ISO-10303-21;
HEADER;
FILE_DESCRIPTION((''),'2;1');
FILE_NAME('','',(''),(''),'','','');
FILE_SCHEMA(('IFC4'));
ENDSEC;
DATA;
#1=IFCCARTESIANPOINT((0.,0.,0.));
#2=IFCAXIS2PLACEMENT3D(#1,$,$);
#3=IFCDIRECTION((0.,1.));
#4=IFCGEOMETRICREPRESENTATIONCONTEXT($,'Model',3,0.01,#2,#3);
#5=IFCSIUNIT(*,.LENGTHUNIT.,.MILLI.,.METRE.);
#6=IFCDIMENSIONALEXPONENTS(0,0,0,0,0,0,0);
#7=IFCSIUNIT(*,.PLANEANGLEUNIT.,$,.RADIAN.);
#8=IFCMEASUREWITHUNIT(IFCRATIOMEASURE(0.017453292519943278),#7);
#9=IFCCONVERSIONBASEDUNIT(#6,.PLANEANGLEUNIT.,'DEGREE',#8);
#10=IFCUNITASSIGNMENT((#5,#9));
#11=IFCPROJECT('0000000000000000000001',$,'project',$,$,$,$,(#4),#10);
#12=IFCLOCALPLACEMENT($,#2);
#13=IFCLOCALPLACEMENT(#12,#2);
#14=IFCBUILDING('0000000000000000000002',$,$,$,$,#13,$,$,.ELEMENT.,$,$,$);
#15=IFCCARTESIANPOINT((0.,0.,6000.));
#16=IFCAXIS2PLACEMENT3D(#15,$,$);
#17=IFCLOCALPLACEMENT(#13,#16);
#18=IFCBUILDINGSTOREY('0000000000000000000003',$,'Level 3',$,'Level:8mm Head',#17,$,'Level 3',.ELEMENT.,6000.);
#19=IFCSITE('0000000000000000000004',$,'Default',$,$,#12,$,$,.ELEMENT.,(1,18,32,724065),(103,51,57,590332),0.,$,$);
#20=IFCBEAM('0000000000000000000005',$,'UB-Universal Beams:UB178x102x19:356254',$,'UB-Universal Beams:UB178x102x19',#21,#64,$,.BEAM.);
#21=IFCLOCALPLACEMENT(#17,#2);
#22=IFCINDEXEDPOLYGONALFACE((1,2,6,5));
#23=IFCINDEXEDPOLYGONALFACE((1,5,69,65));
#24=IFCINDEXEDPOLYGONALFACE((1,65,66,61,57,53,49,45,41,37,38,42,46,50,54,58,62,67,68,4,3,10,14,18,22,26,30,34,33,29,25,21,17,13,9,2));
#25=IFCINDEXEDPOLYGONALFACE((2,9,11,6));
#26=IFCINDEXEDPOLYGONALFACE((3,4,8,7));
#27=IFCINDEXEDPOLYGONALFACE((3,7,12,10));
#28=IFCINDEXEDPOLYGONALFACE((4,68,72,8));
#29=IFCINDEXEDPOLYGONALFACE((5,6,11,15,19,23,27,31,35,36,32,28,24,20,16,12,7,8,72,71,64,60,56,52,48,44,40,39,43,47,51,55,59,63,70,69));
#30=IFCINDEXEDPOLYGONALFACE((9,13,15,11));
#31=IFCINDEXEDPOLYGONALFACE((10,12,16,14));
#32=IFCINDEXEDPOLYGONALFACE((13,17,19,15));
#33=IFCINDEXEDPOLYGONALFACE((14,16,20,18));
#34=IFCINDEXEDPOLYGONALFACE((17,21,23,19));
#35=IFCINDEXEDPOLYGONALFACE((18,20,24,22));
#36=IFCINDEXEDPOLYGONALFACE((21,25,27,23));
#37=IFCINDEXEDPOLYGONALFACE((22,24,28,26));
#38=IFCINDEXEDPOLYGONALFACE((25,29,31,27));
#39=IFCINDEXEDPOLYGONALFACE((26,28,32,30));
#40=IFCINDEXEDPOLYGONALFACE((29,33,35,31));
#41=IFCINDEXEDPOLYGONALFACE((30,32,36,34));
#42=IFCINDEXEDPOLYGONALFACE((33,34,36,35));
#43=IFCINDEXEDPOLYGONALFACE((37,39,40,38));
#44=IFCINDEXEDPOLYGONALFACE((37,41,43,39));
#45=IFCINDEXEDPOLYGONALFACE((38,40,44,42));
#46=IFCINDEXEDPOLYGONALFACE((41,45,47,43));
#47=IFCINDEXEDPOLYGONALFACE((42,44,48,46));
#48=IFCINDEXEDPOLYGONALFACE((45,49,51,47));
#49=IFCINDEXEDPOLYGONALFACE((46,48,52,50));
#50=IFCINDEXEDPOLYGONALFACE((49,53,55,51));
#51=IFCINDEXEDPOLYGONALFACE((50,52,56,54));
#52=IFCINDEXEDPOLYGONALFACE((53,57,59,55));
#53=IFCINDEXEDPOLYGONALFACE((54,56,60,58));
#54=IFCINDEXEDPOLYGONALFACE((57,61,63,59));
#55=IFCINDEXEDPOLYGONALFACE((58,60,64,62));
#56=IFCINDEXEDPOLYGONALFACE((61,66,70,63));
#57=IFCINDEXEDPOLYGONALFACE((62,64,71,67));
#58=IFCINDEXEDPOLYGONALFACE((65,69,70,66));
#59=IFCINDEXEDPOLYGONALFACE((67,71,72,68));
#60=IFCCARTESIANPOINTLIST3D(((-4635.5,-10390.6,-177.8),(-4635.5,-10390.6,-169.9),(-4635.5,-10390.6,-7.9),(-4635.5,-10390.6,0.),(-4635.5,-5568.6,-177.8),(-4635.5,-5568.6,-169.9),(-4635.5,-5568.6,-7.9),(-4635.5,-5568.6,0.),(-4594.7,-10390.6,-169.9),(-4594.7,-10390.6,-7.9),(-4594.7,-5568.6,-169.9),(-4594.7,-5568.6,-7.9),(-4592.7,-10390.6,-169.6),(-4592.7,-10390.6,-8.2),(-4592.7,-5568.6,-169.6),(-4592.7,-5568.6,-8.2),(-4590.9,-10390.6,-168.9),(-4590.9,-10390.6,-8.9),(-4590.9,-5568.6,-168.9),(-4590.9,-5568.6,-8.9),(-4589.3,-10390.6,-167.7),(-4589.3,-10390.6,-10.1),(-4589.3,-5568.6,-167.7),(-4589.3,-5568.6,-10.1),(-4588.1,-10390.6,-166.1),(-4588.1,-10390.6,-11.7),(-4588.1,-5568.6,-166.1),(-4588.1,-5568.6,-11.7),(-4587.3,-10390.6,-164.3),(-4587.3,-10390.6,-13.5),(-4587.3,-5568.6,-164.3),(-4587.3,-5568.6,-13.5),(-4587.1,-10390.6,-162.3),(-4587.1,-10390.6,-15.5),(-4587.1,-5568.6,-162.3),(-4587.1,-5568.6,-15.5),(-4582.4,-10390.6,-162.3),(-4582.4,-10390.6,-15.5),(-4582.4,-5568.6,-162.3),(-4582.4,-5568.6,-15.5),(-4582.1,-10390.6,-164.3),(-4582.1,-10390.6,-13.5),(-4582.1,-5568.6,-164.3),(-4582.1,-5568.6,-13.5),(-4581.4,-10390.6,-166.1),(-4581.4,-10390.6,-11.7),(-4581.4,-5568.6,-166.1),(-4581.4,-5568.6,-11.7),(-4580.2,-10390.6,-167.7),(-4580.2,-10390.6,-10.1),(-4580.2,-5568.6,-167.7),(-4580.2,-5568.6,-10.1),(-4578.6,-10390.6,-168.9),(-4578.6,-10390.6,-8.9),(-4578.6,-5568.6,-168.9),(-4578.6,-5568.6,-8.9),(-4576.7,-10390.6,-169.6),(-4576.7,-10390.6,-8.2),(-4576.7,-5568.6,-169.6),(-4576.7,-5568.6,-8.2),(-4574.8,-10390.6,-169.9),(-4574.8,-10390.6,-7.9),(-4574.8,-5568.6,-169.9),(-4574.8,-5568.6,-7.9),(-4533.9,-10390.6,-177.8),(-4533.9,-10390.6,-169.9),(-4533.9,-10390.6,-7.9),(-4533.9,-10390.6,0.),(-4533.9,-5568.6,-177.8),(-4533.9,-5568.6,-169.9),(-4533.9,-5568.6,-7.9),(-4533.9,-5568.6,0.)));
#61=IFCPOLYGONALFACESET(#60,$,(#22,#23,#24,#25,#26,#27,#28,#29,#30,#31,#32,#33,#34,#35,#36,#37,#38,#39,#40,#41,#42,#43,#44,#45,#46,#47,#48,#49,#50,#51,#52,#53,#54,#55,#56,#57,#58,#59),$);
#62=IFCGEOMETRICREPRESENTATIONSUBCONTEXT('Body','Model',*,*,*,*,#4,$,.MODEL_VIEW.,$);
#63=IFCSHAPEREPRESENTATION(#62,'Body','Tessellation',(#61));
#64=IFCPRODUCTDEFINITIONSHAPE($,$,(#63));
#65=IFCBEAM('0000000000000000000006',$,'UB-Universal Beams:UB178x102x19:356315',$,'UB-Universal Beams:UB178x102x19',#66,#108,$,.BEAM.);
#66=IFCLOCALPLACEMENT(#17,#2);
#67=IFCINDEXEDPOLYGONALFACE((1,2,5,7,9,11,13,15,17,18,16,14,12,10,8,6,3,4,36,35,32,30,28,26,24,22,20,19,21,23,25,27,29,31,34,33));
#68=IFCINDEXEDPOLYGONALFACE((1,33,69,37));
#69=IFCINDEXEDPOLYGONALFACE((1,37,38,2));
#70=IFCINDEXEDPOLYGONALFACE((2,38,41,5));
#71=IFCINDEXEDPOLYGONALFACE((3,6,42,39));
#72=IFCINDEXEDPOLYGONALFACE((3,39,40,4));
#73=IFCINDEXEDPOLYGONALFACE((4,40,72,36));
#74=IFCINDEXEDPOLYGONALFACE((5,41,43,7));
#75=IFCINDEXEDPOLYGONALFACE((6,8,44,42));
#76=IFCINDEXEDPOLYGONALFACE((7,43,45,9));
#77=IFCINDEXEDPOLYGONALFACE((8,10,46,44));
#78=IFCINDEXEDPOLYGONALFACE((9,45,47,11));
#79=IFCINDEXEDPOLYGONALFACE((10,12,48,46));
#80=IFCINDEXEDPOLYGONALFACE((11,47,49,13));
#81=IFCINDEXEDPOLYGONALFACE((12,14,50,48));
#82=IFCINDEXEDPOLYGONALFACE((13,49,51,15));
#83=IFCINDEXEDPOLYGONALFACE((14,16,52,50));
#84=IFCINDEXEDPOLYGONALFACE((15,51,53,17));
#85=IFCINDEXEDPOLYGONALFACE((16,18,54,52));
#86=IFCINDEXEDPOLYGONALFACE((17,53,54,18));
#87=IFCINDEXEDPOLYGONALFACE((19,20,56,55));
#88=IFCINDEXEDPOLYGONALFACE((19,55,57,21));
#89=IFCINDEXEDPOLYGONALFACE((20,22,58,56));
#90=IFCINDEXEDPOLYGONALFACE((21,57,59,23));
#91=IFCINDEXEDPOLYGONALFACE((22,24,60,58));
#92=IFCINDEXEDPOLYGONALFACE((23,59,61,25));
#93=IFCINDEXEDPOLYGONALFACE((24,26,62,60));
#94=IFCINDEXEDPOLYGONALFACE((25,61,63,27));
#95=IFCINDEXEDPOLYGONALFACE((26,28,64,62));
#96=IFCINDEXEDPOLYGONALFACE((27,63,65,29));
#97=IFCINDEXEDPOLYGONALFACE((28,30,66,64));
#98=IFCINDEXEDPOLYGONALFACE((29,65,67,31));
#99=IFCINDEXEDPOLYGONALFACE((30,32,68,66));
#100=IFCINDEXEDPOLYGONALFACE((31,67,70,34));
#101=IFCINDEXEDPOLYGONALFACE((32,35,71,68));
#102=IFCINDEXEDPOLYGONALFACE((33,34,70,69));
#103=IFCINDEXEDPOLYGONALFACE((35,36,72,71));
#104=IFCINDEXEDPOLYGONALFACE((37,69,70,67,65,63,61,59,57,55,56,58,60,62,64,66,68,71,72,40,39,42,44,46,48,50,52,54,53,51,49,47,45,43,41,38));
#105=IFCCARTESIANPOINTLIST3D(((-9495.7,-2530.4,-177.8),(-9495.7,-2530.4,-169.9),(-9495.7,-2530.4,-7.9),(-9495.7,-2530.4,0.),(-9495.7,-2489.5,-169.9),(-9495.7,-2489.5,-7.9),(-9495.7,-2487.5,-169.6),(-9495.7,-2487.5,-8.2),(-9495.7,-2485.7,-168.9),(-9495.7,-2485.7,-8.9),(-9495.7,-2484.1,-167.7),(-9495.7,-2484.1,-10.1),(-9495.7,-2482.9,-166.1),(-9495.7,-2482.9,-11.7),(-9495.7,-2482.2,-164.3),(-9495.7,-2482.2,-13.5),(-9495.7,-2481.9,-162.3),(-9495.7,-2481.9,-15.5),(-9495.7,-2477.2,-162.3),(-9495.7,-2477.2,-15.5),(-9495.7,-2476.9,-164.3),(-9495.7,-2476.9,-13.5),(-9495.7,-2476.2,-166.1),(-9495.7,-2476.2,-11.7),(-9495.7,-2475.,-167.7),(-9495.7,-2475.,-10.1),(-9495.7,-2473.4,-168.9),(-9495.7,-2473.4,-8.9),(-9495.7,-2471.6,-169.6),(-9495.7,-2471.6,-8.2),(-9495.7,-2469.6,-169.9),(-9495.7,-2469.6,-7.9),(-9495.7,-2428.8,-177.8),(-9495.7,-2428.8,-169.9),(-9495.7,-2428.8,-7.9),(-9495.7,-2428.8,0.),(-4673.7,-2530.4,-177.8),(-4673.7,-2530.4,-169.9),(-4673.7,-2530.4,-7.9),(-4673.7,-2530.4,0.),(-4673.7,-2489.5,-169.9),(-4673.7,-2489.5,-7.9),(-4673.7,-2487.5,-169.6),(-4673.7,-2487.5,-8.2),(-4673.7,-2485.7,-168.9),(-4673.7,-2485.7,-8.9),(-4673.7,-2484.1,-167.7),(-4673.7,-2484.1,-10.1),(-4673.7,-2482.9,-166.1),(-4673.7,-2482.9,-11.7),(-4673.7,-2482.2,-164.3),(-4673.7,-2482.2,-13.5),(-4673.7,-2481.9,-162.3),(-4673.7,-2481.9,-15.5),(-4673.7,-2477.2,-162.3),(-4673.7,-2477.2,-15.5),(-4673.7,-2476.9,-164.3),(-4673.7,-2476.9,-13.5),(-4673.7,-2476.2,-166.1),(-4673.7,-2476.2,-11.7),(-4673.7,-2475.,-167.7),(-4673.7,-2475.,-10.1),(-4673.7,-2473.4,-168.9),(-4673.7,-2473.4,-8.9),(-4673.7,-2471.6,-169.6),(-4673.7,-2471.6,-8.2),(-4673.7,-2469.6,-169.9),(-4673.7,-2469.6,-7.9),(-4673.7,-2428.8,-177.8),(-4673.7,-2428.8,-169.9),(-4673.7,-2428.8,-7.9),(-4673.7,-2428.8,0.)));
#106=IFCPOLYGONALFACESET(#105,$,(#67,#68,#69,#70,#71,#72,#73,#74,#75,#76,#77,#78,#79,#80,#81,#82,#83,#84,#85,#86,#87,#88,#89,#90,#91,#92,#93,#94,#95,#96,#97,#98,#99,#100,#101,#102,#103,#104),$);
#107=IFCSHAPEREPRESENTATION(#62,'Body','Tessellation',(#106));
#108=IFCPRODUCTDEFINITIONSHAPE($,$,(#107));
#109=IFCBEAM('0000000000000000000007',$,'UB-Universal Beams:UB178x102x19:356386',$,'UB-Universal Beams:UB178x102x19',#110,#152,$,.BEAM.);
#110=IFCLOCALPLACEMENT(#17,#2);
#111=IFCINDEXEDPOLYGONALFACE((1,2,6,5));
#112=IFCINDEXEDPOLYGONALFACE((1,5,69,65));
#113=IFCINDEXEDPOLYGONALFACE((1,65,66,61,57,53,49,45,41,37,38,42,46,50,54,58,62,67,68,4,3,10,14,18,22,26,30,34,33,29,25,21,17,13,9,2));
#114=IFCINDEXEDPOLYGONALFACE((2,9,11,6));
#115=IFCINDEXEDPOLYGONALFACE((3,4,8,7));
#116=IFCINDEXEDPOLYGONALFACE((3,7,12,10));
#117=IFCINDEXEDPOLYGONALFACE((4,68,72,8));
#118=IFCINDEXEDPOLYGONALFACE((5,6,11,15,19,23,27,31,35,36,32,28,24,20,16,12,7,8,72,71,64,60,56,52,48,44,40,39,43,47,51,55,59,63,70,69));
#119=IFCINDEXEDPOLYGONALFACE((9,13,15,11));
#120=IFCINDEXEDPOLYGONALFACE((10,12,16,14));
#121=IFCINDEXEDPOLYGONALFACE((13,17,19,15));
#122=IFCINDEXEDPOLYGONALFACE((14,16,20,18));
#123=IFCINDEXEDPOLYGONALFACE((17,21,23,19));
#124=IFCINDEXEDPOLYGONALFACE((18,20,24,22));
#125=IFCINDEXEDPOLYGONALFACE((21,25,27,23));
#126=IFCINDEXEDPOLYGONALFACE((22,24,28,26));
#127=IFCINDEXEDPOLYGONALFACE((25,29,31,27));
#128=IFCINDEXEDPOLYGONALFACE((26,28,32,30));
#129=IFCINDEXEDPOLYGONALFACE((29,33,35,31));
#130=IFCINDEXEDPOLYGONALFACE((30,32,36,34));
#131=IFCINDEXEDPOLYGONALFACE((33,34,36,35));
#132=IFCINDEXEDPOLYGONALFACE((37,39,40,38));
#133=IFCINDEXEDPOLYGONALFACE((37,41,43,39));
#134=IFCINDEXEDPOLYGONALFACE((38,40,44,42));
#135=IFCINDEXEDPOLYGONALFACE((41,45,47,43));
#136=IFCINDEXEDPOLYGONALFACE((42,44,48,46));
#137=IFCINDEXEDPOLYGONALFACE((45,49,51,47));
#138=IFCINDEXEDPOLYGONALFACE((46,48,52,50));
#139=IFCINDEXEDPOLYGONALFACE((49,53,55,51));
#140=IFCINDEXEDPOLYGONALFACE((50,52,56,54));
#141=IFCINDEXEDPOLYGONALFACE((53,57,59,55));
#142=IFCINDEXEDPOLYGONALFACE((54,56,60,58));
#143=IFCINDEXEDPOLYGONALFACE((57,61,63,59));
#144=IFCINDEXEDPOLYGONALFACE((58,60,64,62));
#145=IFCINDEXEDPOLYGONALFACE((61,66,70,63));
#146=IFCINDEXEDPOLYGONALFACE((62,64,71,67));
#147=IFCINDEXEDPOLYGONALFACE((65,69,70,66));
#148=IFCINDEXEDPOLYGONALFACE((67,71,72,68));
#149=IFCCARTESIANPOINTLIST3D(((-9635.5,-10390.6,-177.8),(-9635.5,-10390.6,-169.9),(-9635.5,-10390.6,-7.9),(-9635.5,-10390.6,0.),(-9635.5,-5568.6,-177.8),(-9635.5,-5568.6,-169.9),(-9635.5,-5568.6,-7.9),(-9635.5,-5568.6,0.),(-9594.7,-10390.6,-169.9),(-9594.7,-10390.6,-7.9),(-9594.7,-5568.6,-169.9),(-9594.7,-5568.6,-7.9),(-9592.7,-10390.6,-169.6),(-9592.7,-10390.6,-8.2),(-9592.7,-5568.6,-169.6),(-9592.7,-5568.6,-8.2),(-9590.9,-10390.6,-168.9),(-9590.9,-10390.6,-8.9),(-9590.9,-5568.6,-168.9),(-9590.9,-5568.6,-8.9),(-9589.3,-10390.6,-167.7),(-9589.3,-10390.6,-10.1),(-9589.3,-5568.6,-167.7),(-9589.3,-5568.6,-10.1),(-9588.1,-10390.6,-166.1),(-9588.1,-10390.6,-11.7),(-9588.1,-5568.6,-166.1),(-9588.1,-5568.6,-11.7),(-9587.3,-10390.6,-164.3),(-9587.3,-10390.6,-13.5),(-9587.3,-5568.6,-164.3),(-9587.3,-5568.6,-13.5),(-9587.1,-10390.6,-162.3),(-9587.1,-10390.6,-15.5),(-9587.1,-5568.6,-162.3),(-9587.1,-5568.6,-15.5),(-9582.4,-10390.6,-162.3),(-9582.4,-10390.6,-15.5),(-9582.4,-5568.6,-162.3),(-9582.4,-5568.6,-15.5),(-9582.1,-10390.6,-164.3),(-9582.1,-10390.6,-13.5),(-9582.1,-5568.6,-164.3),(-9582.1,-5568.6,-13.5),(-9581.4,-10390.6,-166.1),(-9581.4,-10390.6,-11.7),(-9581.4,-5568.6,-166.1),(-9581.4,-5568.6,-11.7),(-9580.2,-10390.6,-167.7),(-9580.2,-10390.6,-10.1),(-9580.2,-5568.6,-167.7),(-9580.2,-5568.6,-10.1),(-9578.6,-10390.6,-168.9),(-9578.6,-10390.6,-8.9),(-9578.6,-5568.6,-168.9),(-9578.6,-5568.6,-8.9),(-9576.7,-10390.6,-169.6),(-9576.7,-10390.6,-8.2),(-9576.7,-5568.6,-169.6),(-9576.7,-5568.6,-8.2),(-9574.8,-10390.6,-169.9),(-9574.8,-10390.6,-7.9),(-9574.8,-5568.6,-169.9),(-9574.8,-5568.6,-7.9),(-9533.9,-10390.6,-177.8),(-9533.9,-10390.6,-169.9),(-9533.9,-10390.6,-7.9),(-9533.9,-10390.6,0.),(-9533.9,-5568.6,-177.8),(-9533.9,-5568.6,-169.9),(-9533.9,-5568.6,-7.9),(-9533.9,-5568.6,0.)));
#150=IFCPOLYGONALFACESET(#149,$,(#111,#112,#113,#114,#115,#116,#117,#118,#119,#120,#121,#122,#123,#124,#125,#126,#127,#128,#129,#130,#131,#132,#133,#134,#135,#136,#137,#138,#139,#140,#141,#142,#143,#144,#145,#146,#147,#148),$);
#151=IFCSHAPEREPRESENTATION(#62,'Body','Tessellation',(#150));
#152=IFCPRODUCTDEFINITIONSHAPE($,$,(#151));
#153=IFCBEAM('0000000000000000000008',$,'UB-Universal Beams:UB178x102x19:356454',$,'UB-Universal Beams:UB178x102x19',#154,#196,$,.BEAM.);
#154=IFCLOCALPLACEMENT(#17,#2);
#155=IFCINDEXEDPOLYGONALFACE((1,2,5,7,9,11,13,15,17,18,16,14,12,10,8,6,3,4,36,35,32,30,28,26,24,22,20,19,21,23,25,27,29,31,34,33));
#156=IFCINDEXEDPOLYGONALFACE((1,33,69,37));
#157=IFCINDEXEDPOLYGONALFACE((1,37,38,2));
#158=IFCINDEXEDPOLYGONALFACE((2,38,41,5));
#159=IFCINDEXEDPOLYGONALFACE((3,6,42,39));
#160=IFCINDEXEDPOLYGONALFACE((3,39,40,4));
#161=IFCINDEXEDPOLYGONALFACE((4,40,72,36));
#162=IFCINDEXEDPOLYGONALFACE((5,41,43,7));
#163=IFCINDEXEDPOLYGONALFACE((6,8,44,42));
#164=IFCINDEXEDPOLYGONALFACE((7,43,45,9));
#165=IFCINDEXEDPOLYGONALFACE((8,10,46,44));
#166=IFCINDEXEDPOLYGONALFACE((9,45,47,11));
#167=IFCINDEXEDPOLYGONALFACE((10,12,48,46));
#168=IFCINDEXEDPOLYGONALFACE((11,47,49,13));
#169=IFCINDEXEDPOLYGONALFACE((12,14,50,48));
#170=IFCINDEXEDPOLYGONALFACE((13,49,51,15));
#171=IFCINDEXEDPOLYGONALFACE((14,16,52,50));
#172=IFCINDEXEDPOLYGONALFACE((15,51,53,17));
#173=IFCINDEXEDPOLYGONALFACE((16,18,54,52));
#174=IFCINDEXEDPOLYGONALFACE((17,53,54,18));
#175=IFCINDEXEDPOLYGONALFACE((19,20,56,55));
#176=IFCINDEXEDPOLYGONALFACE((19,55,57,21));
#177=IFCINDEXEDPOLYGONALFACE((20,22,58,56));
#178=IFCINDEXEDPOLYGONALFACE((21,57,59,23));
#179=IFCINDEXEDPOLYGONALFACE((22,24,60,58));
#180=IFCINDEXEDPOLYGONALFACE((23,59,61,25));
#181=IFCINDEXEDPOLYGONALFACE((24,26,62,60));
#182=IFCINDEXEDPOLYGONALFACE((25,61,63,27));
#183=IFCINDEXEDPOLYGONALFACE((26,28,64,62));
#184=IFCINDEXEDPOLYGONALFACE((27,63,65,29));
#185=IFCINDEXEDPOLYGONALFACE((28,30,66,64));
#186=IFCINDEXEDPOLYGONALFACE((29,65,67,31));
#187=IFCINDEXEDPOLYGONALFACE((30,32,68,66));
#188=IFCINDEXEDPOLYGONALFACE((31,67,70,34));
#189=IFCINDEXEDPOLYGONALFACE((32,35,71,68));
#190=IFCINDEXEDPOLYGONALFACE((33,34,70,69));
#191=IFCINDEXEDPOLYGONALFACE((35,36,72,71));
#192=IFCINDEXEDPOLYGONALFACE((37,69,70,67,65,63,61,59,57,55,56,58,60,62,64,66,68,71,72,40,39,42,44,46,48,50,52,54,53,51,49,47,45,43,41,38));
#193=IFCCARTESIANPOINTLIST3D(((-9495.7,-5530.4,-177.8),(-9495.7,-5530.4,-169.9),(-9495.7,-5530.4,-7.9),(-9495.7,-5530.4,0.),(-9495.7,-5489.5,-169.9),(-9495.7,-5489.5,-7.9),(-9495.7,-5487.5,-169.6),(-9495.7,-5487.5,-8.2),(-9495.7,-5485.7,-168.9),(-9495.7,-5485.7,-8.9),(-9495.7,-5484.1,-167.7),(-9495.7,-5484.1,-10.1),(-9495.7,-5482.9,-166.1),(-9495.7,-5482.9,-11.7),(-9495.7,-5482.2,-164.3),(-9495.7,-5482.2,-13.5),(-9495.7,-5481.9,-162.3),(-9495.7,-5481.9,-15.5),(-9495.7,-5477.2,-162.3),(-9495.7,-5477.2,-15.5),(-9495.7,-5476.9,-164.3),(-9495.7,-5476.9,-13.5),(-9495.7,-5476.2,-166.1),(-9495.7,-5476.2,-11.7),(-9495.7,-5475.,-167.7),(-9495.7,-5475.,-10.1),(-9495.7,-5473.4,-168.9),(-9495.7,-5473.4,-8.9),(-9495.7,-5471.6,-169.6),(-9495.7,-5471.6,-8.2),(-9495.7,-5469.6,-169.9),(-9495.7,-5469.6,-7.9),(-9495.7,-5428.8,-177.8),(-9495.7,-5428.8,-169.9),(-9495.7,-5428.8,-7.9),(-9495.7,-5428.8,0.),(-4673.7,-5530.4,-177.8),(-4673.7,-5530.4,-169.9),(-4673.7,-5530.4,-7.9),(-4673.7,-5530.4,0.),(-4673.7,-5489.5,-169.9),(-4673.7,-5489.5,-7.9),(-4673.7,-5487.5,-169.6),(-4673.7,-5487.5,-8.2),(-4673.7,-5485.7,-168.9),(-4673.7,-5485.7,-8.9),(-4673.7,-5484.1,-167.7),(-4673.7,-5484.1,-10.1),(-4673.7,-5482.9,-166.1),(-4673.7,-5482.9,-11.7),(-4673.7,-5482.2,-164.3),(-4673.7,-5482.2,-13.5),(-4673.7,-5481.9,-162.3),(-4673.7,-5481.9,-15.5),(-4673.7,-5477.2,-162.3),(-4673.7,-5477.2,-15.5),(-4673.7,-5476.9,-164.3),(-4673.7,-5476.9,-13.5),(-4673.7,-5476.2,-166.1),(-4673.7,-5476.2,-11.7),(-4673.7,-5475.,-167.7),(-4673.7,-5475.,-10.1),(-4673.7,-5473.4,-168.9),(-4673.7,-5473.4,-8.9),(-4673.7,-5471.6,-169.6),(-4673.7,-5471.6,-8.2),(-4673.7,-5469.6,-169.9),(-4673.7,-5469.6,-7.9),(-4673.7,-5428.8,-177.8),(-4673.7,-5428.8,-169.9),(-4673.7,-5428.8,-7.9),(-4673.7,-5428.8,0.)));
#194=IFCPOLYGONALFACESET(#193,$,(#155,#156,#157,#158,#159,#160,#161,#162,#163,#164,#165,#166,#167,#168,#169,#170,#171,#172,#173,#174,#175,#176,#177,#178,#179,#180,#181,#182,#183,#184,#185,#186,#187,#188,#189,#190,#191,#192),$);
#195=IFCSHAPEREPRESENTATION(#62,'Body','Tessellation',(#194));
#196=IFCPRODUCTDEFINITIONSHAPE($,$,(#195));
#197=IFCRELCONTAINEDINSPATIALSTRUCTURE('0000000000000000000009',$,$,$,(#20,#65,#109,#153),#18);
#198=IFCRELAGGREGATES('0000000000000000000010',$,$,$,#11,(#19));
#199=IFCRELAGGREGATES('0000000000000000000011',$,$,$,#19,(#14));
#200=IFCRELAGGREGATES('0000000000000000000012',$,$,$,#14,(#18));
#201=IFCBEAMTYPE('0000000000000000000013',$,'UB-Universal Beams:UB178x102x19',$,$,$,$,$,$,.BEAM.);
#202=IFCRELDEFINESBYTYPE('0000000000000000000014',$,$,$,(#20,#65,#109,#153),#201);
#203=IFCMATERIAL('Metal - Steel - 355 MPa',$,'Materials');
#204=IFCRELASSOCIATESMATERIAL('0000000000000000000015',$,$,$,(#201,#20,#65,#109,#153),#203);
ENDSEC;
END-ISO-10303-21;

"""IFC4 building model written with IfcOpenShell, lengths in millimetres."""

from ifc_helpers import new_model, entity, si_unit, converted_unit, direction, frame, origin, place, context, subcontext, project, spatial, line, arc, indexed_curve, outline, extrude, source, transform, mapped, material, type_object, type_shapes, element, save


model = new_model("IFC4")

# Units and contexts
model_context = context("Model", 3, precision=0.01, world=origin(), true_north=direction((0.0, 1.0)))
body_context = subcontext(model_context, "Body", "Model", "MODEL_VIEW")
ifc_project = project(units=[si_unit("LENGTHUNIT", "METRE", prefix="MILLI"), converted_unit("PLANEANGLEUNIT", "DEGREE", entity("IfcRatioMeasure", 0.017453292519943278), si_unit("PLANEANGLEUNIT", "RADIAN"), dimensions=[0, 0, 0, 0, 0, 0, 0])], contexts=[model_context])

# Site, building, storey
site_placement = place(None, origin())
site = spatial("IfcSite", under=ifc_project, at=site_placement, Name="Default", CompositionType="ELEMENT", RefLatitude=(1, 18, 32, 724065), RefLongitude=(103, 51, 57, 590332), RefElevation=0.0)
building_placement = place(site_placement, origin())
building = spatial("IfcBuilding", under=site, at=building_placement, CompositionType="ELEMENT")
storey_placement = place(building_placement, frame((0.0, 0.0, 6000.0)))
storey = spatial("IfcBuildingStorey", under=building, at=storey_placement, Name="Level 3", ObjectType="Level:8mm Head", LongName="Level 3", CompositionType="ELEMENT", Elevation=6000.0)

# Shared definitions
ifc_material = material(Name="Metal - Steel - 355 MPa", Category="Materials")

# Beams
beam_type_1 = type_object("IfcBeamType", Name="UB-Universal Beams:UB178x102x19", PredefinedType="BEAM", material=ifc_material)
shared_shape_1 = source(origin(), body_context, "Body", "SweptSolid", [
    extrude(outline(indexed_curve([(-88.9, -50.8), (-81.0, -50.8), (-81.0, -9.9), (-78.8, -4.6), (-73.4, -2.3), (73.4, -2.3), (78.8, -4.6), (81.0, -9.9), (81.0, -50.8), (88.9, -50.8), (88.9, 50.8), (81.0, 50.8), (81.0, 10.0), (78.8, 4.6), (73.4, 2.4), (-73.4, 2.4), (-78.8, 4.6), (-81.0, 10.0), (-81.0, 50.8), (-88.9, 50.8)], segments=[line(1, 2, 3), arc(3, 4, 5), line(5, 6), arc(6, 7, 8), line(8, 9, 10, 11, 12, 13), arc(13, 14, 15), line(15, 16), arc(16, 17, 18), line(18, 19, 20, 1)], self_intersect=False)), frame((-2411.0, 0.0, 0.0), z_axis=(1.0, 0.0, 0.0), x_axis=(0.0, 0.0, -1.0)), (0.0, 0.0, 1.0), 4822.0),
])
type_shapes(beam_type_1, [shared_shape_1])
for number, where, z_axis, x_axis, name in (
    (1, (-4584.7, -7979.6, -88.9), (0.0, 0.0, 1.0), (0.0, 1.0, 0.0), "UB-Universal Beams:UB178x102x19:356254"),
    (2, (-7084.7, -2479.6, -88.9), (0.0, 0.0, 1.0), (-1.0, 0.0, 0.0), "UB-Universal Beams:UB178x102x19:356315"),
    (3, (-9584.7, -7979.6, -88.9), (0.0, 0.0, 1.0), (0.0, -1.0, 0.0), "UB-Universal Beams:UB178x102x19:356386"),
    (4, (-7084.7, -5479.6, -88.9), (0.0, 0.0, 1.0), (-1.0, 0.0, 0.0), "UB-Universal Beams:UB178x102x19:356454"),
):
    element("IfcBeam", number, at=place(storey_placement, frame(where, z_axis=z_axis, x_axis=x_axis)), inside=storey, type_object=beam_type_1, material=ifc_material, Name=name, ObjectType="UB-Universal Beams:UB178x102x19", PredefinedType="BEAM", context=body_context, shape_type="MappedRepresentation", body=[
        mapped(shared_shape_1, transform((0.0, 0.0, 0.0), scale=1.0)),
    ])

save(model, "model.ifc")
